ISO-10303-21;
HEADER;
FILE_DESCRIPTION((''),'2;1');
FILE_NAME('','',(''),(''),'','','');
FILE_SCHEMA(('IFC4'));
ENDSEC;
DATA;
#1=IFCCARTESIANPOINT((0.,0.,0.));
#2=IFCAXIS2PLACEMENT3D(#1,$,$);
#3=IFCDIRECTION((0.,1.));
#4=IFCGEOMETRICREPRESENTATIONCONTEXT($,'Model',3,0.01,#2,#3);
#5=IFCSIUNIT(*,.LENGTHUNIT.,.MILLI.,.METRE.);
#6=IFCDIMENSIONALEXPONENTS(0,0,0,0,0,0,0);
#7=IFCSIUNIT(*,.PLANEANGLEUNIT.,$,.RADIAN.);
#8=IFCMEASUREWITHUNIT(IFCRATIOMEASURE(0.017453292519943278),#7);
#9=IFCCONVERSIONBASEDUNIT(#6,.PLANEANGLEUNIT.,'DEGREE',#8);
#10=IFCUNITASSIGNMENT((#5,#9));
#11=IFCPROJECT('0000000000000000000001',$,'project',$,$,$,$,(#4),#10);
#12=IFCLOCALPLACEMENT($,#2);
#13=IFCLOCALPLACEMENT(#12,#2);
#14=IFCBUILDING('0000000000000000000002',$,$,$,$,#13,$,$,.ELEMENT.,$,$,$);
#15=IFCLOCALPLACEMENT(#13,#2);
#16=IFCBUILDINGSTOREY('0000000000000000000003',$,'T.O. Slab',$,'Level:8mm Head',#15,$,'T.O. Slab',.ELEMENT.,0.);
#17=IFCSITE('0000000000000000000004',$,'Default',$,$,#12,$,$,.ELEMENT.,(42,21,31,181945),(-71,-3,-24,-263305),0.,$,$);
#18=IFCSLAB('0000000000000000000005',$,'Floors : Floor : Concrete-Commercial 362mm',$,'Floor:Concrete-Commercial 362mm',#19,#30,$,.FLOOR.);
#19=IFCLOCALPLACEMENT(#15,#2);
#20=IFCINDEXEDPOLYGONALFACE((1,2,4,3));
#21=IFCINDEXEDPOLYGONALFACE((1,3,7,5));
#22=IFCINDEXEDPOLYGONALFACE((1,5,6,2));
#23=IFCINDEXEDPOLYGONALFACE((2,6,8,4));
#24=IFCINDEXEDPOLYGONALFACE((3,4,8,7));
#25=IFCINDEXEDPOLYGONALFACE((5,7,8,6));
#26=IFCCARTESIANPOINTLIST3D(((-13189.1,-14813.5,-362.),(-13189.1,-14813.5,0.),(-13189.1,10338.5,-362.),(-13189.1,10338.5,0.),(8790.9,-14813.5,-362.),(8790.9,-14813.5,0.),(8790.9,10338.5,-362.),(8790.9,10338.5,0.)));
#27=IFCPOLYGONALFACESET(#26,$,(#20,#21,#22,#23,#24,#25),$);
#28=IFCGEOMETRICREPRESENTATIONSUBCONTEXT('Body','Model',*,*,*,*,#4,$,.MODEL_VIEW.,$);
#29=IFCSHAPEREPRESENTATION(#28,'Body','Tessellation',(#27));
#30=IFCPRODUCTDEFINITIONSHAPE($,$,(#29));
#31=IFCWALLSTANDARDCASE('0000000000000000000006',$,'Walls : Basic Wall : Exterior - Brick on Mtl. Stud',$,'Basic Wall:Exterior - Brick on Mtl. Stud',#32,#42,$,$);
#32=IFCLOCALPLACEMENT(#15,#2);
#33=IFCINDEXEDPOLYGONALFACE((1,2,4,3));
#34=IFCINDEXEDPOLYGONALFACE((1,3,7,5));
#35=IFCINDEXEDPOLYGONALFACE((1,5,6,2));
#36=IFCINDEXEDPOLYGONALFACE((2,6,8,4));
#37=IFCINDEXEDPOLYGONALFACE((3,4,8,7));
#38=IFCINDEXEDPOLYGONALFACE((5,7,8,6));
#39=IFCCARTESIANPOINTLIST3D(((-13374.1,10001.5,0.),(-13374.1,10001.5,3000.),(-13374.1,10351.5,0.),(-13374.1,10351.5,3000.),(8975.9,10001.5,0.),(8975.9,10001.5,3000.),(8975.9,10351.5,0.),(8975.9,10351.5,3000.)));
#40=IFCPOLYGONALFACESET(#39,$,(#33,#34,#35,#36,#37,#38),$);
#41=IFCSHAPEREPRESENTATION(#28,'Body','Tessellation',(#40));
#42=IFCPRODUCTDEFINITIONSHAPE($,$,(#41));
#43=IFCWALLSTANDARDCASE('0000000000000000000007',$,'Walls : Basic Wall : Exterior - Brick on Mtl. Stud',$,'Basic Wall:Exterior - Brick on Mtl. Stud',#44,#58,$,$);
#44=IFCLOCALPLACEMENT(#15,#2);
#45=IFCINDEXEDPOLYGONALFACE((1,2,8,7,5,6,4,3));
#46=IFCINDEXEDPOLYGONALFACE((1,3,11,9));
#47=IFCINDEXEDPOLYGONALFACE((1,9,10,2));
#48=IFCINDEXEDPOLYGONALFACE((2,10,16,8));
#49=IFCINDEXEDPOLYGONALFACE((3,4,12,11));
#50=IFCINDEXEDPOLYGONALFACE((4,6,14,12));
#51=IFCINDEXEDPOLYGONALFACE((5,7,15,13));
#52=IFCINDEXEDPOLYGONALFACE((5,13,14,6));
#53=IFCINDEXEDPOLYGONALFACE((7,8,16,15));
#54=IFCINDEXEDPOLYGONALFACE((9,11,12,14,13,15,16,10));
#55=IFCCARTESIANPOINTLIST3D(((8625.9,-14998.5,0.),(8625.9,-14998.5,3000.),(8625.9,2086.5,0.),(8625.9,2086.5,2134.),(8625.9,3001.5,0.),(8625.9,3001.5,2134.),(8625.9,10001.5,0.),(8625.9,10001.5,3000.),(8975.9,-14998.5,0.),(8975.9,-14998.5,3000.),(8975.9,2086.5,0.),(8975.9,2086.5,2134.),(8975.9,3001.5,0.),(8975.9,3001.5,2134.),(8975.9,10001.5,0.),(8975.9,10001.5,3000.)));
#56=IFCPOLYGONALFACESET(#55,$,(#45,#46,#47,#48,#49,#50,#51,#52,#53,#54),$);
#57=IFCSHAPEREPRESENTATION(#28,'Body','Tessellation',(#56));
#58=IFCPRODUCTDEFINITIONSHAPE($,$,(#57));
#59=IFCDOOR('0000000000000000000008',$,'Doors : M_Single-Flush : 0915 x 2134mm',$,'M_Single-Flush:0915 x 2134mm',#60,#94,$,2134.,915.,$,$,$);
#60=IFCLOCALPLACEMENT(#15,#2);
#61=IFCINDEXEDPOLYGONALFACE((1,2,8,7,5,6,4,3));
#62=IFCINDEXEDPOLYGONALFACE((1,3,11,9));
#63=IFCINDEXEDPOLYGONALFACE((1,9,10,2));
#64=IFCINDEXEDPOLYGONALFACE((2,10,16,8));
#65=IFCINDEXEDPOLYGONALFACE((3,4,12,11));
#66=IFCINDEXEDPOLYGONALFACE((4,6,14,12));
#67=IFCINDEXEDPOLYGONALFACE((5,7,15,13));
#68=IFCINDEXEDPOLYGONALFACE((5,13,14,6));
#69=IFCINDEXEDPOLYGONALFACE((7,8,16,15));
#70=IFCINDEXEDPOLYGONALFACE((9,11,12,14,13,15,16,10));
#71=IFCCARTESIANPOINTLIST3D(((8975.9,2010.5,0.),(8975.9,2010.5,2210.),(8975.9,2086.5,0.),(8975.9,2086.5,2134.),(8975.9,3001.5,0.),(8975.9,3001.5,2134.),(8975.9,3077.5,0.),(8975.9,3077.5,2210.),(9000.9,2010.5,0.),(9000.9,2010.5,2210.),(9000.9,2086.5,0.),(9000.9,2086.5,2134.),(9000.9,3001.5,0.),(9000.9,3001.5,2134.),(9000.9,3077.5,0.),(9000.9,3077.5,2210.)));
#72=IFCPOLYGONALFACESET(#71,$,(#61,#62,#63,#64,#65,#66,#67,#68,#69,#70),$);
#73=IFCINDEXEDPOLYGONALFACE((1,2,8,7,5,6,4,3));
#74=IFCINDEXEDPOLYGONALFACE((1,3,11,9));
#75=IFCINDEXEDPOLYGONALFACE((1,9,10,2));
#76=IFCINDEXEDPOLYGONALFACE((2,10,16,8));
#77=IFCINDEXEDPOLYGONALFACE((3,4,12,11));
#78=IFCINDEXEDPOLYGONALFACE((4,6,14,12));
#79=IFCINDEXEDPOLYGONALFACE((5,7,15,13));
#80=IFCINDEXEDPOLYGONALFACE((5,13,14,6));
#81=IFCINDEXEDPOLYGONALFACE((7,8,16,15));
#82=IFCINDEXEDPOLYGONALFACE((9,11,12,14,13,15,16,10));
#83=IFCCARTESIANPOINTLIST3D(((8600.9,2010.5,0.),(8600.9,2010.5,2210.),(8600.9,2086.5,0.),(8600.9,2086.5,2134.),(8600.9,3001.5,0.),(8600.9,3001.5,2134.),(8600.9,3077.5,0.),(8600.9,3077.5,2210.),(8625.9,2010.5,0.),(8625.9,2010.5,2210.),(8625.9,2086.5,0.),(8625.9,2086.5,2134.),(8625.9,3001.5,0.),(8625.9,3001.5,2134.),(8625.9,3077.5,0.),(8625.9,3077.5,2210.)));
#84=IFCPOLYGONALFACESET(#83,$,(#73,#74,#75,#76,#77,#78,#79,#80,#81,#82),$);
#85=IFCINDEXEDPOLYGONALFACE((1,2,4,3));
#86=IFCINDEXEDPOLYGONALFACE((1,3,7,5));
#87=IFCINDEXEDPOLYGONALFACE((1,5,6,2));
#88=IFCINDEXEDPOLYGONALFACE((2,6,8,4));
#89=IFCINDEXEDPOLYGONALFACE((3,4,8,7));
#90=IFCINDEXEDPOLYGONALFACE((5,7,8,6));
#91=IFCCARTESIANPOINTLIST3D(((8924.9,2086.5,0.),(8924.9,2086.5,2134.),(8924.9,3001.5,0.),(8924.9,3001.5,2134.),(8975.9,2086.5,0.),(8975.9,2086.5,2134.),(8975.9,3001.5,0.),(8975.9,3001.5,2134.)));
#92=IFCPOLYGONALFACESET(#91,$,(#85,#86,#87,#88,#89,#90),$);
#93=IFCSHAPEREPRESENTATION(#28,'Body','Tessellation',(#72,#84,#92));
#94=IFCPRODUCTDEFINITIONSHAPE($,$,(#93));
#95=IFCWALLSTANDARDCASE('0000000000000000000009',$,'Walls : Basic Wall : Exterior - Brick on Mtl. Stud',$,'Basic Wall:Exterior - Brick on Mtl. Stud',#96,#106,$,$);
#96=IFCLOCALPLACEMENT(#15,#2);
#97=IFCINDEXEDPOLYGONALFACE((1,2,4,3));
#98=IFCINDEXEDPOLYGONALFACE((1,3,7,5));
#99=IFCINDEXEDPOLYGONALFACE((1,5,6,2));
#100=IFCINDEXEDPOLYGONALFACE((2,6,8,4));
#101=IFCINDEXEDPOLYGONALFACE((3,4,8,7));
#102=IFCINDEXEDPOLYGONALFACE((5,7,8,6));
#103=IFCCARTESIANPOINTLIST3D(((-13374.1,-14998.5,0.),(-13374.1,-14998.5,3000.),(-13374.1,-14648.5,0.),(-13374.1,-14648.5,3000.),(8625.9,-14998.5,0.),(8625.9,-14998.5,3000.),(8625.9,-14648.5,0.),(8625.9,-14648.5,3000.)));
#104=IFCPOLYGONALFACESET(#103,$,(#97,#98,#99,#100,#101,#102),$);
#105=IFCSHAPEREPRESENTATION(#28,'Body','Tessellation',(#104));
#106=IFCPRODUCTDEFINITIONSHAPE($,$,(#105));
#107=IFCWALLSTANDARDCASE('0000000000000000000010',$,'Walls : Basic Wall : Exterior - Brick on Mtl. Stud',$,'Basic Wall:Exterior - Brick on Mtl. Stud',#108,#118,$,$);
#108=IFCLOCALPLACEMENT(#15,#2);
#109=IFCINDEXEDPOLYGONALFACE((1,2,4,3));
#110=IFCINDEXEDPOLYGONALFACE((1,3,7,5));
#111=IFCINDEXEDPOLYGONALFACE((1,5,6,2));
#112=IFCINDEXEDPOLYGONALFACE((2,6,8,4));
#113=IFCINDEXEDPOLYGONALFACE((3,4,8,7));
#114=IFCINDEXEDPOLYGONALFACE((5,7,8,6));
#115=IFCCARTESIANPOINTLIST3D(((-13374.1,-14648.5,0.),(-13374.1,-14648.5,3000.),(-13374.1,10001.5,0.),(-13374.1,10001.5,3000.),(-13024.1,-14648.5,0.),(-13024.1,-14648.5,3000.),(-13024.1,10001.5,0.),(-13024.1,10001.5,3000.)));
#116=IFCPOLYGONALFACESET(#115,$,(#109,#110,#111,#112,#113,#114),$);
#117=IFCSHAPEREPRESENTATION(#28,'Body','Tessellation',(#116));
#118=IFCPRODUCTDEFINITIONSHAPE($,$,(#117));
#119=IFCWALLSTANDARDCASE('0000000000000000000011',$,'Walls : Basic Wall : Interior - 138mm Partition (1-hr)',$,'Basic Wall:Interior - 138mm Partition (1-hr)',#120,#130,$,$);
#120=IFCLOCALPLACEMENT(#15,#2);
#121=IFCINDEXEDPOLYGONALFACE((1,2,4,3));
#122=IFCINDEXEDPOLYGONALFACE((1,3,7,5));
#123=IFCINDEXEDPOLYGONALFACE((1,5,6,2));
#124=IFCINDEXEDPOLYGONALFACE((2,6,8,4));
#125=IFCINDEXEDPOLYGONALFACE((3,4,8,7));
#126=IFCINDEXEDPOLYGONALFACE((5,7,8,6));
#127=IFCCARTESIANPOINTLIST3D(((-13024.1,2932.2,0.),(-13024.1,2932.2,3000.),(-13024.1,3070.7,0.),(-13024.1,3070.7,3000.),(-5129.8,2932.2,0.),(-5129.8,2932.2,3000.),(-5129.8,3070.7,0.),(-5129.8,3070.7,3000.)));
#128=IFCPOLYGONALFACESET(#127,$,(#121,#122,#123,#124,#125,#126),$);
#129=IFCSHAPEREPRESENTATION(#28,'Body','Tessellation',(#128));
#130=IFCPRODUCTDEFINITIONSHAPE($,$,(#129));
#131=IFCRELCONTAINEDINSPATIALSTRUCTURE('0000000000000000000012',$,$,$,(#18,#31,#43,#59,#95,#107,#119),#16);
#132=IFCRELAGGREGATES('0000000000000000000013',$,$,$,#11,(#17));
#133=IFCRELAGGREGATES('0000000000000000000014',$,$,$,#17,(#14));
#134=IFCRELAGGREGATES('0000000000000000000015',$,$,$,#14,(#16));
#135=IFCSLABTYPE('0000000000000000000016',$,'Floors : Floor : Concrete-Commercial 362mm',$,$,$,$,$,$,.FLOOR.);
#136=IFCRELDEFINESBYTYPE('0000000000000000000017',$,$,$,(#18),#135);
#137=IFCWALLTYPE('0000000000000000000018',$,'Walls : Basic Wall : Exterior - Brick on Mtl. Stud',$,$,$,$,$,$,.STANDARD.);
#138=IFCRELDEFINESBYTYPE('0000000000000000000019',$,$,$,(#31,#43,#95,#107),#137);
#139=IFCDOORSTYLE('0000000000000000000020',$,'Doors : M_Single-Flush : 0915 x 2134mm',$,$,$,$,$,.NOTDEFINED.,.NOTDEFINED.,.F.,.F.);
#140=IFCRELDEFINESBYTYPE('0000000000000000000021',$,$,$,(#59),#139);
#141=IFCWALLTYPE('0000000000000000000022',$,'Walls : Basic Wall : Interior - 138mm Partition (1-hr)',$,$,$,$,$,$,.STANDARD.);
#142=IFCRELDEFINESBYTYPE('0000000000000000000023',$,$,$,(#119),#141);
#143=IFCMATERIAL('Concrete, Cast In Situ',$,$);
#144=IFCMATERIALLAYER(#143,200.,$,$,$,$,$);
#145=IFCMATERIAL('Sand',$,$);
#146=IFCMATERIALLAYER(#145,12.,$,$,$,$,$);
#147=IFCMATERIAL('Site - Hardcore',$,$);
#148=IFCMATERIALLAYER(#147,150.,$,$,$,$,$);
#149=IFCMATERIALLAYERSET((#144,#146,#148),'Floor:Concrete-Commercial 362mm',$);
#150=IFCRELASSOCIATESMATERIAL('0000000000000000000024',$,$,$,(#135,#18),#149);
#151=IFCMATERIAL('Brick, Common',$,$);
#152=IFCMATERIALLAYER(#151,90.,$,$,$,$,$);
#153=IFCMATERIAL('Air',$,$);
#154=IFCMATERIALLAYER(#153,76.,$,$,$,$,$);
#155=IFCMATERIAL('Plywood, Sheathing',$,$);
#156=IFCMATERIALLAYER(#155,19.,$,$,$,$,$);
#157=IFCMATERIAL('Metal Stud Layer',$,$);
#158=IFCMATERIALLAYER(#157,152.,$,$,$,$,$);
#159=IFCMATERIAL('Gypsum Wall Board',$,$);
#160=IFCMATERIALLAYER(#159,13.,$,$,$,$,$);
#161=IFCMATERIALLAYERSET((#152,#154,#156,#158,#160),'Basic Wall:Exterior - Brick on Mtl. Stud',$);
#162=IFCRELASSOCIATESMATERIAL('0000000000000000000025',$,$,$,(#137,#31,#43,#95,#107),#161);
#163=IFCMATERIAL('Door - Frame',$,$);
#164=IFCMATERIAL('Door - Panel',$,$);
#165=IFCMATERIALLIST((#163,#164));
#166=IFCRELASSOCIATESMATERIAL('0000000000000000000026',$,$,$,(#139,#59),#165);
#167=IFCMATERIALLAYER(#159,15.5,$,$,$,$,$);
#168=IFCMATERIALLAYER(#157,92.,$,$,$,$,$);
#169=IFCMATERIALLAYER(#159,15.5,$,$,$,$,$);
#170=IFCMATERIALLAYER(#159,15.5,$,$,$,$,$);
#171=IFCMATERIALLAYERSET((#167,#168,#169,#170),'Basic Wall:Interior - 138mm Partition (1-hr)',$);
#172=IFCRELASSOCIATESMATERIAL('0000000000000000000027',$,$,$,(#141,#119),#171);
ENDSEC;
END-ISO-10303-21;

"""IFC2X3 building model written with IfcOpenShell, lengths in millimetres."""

from ifc_helpers import new_model, entity, si_unit, converted_unit, direction, frame, frame_2d, origin, place, context, subcontext, project, spatial, polyline, rectangle, outline, extrude, clip, halfspace, source, transform, mapped, material, material_list, layer, layer_set, layer_usage, type_object, type_shapes, element, fill, save


model = new_model("IFC2X3")

# Units and contexts
model_context = context("Model", 3, precision=0.01, world=origin(), true_north=direction((0.0, 1.0)))
body_context = subcontext(model_context, "Body", "Model", "MODEL_VIEW")
ifc_project = project(units=[si_unit("LENGTHUNIT", "METRE", prefix="MILLI"), converted_unit("PLANEANGLEUNIT", "DEGREE", entity("IfcRatioMeasure", 0.017453292519943278), si_unit("PLANEANGLEUNIT", "RADIAN"), dimensions=[0, 0, 0, 0, 0, 0, 0])], contexts=[model_context])

# Site, building, storey
site_placement = place(None, origin())
site = spatial("IfcSite", under=ifc_project, at=site_placement, Name="Default", CompositionType="ELEMENT", RefLatitude=(42, 21, 31, 181945), RefLongitude=(-71, -3, -24, -263305), RefElevation=0.0)
building_placement = place(site_placement, origin())
building = spatial("IfcBuilding", under=site, at=building_placement, CompositionType="ELEMENT")
storey_placement = place(building_placement, origin())
storey = spatial("IfcBuildingStorey", under=building, at=storey_placement, Name="T.O. Slab", ObjectType="Level:8mm Head", LongName="T.O. Slab", CompositionType="ELEMENT", Elevation=0.0)

# Slab
ifc_material_1 = material(Name="Concrete, Cast In Situ")
ifc_layer_1 = layer(ifc_material_1, 200.0)
ifc_material_2 = material(Name="Sand")
ifc_layer_2 = layer(ifc_material_2, 12.0)
ifc_material_3 = material(Name="Site - Hardcore")
ifc_layer_3 = layer(ifc_material_3, 150.0)
ifc_layer_set_1 = layer_set([ifc_layer_1, ifc_layer_2, ifc_layer_3], Name="Floor:Concrete-Commercial 362mm")
ifc_layer_usage_1 = layer_usage(ifc_layer_set_1, "AXIS3", "POSITIVE", 0.0)
slab_type = type_object("IfcSlabType", Name="Floors : Floor : Concrete-Commercial 362mm", PredefinedType="FLOOR", material=ifc_layer_set_1)
slab_placement = place(storey_placement, origin())
element("IfcSlab", 1, at=slab_placement, inside=storey, type_object=slab_type, material=ifc_layer_usage_1, Name="Floors : Floor : Concrete-Commercial 362mm", ObjectType="Floor:Concrete-Commercial 362mm", PredefinedType="FLOOR", context=body_context, shape_type="SweptSolid", body=[
    extrude(rectangle(XDim=25152.0, YDim=21980.0, at=frame_2d((0.0, 0.0), x_axis=(1.0, 0.0))), frame((-2199.1, -2237.5, 0.0), z_axis=(0.0, 0.0, -1.0), x_axis=(0.0, 1.0, 0.0)), (0.0, 0.0, 1.0), 362.0),
])

# Wall
ifc_material_4 = material(Name="Brick, Common")
ifc_layer_4 = layer(ifc_material_4, 90.0)
ifc_material_5 = material(Name="Air")
ifc_layer_5 = layer(ifc_material_5, 76.0)
ifc_material_6 = material(Name="Plywood, Sheathing")
ifc_layer_6 = layer(ifc_material_6, 19.0)
ifc_material_7 = material(Name="Metal Stud Layer")
ifc_layer_7 = layer(ifc_material_7, 152.0)
ifc_material_8 = material(Name="Gypsum Wall Board")
ifc_layer_8 = layer(ifc_material_8, 13.0)
ifc_layer_set_2 = layer_set([ifc_layer_4, ifc_layer_5, ifc_layer_6, ifc_layer_7, ifc_layer_8], Name="Basic Wall:Exterior - Brick on Mtl. Stud")
ifc_layer_usage_2 = layer_usage(ifc_layer_set_2, "AXIS2", "POSITIVE", -175.0)
wall_type_1 = type_object("IfcWallType", Name="Walls : Basic Wall : Exterior - Brick on Mtl. Stud", PredefinedType="STANDARD", material=ifc_layer_set_2)
wall_1_placement = place(storey_placement, frame((-13374.1, 10176.5, 0.0)))
element("IfcWallStandardCase", 2, at=wall_1_placement, inside=storey, type_object=wall_type_1, material=ifc_layer_usage_2, Name="Walls : Basic Wall : Exterior - Brick on Mtl. Stud", ObjectType="Basic Wall:Exterior - Brick on Mtl. Stud", context=body_context, shape_type="Clipping", body=[
    clip(extrude(rectangle(XDim=22350.0, YDim=350.0, at=frame_2d((11175.0, 0.0), x_axis=(-1.0, 0.0))), origin(), (0.0, 0.0, 1.0), 3000.0), halfspace(origin(), True)),
])

# Wall, opening, door
ifc_layer_usage_3 = layer_usage(ifc_layer_set_2, "AXIS2", "NEGATIVE", 175.0)
wall_2_placement = place(storey_placement, frame((8800.9, 10001.5, 0.0), z_axis=(0.0, 0.0, 1.0), x_axis=(0.0, -1.0, 0.0)))
wall_2 = element("IfcWallStandardCase", 3, at=wall_2_placement, inside=storey, type_object=wall_type_1, material=ifc_layer_usage_3, Name="Walls : Basic Wall : Exterior - Brick on Mtl. Stud", ObjectType="Basic Wall:Exterior - Brick on Mtl. Stud", context=body_context, shape_type="Clipping", body=[
    clip(extrude(rectangle(XDim=25000.0, YDim=350.0, at=frame_2d((12500.0, 0.0), x_axis=(1.0, 0.0))), origin(), (0.0, 0.0, 1.0), 3000.0), halfspace(origin(), True)),
])
opening_1_placement = place(wall_2_placement, frame((7000.0, -175.0, 0.0)))
opening_1 = element("IfcOpeningElement", 4, at=opening_1_placement, cuts=wall_2, ObjectType="Opening", context=body_context, shape_type="SweptSolid", body=[
    extrude(rectangle(XDim=915.0, YDim=2134.0, at=frame_2d((1067.0, 457.5), x_axis=(0.0, 1.0))), frame((0.0, 0.0, 0.0), z_axis=(0.0, 1.0, 0.0), x_axis=(0.0, 0.0, 1.0)), (0.0, 0.0, 1.0), 350.0),
])
ifc_material_9 = material(Name="Door - Frame")
ifc_material_10 = material(Name="Door - Panel")
ifc_material_list = material_list([ifc_material_9, ifc_material_10])
door_style_1 = type_object("IfcDoorStyle", Name="Doors : M_Single-Flush : 0915 x 2134mm", ConstructionType="NOTDEFINED", OperationType="NOTDEFINED", ParameterTakesPrecedence=False, Sizeable=False, material=ifc_material_list)
shared_shape_1 = source(origin(), body_context, "Body", "SweptSolid", [
    extrude(outline(polyline([(-533.5, -1124.0), (533.5, -1124.0), (533.5, 1086.0), (457.5, 1086.0), (457.5, -1048.0), (-457.5, -1048.0), (-457.5, 1086.0), (-533.5, 1086.0), (-533.5, -1124.0)])), frame((457.5, 350.0, 1086.0), z_axis=(0.0, 1.0, 0.0), x_axis=(1.0, 0.0, 0.0)), (0.0, 0.0, 1.0), 25.0),
    extrude(outline(polyline([(-1124.0, -533.5), (1086.0, -533.5), (1086.0, -457.5), (-1048.0, -457.5), (-1048.0, 457.5), (1086.0, 457.5), (1086.0, 533.5), (-1124.0, 533.5), (-1124.0, -533.5)])), frame((457.5, -25.0, 1086.0), z_axis=(0.0, 1.0, 0.0), x_axis=(0.0, 0.0, -1.0)), (0.0, 0.0, 1.0), 25.0),
    extrude(rectangle(XDim=51.0, YDim=915.0, at=frame_2d((0.0, 0.0), x_axis=(1.0, 0.0))), frame((457.5, 324.5, 0.0), z_axis=(0.0, 0.0, 1.0), x_axis=(0.0, 1.0, 0.0)), (0.0, 0.0, 1.0), 2134.0),
])
type_shapes(door_style_1, [shared_shape_1])
door_1_placement = place(opening_1_placement, origin())
door_1 = element("IfcDoor", 5, at=door_1_placement, inside=storey, type_object=door_style_1, material=ifc_material_list, Name="Doors : M_Single-Flush : 0915 x 2134mm", ObjectType="M_Single-Flush:0915 x 2134mm", OverallHeight=2134.0, OverallWidth=915.0, context=body_context, shape_type="MappedRepresentation", body=[
    mapped(shared_shape_1, transform((0.0, 0.0, 0.0), scale=1.0)),
])
fill(opening_1, door_1)

# Walls
wall_3_placement = place(storey_placement, frame((8625.9, -14823.5, 0.0), z_axis=(0.0, 0.0, 1.0), x_axis=(-1.0, 0.0, 0.0)))
element("IfcWallStandardCase", 6, at=wall_3_placement, inside=storey, type_object=wall_type_1, material=ifc_layer_usage_3, Name="Walls : Basic Wall : Exterior - Brick on Mtl. Stud", ObjectType="Basic Wall:Exterior - Brick on Mtl. Stud", context=body_context, shape_type="Clipping", body=[
    clip(extrude(rectangle(XDim=22000.0, YDim=350.0, at=frame_2d((11000.0, 0.0), x_axis=(-1.0, 0.0))), origin(), (0.0, 0.0, 1.0), 3000.0), halfspace(origin(), True)),
])
wall_4_placement = place(storey_placement, frame((-13199.1, -14648.5, 0.0), z_axis=(0.0, 0.0, 1.0), x_axis=(0.0, 1.0, 0.0)))
element("IfcWallStandardCase", 7, at=wall_4_placement, inside=storey, type_object=wall_type_1, material=ifc_layer_usage_3, Name="Walls : Basic Wall : Exterior - Brick on Mtl. Stud", ObjectType="Basic Wall:Exterior - Brick on Mtl. Stud", context=body_context, shape_type="Clipping", body=[
    clip(extrude(rectangle(XDim=24650.0, YDim=350.0, at=frame_2d((12325.0, 0.0), x_axis=(-1.0, 0.0))), origin(), (0.0, 0.0, 1.0), 3000.0), halfspace(origin(), True)),
])
ifc_layer_9 = layer(ifc_material_8, 15.5)
ifc_layer_10 = layer(ifc_material_7, 92.0)
ifc_layer_11 = layer(ifc_material_8, 15.5)
ifc_layer_12 = layer(ifc_material_8, 15.5)
ifc_layer_set_3 = layer_set([ifc_layer_9, ifc_layer_10, ifc_layer_11, ifc_layer_12], Name="Basic Wall:Interior - 138mm Partition (1-hr)")
ifc_layer_usage_4 = layer_usage(ifc_layer_set_3, "AXIS2", "POSITIVE", -69.2)
wall_type_2 = type_object("IfcWallType", Name="Walls : Basic Wall : Interior - 138mm Partition (1-hr)", PredefinedType="STANDARD", material=ifc_layer_set_3)
wall_5_placement = place(storey_placement, frame((-13024.1, 3001.5, 0.0)))
element("IfcWallStandardCase", 8, at=wall_5_placement, inside=storey, type_object=wall_type_2, material=ifc_layer_usage_4, Name="Walls : Basic Wall : Interior - 138mm Partition (1-hr)", ObjectType="Basic Wall:Interior - 138mm Partition (1-hr)", context=body_context, shape_type="Clipping", body=[
    clip(extrude(rectangle(XDim=7894.2, YDim=138.5, at=frame_2d((3947.1, 0.0), x_axis=(-1.0, 0.0))), origin(), (0.0, 0.0, 1.0), 3000.0), halfspace(origin(), True)),
])

save(model, "model.ifc")
